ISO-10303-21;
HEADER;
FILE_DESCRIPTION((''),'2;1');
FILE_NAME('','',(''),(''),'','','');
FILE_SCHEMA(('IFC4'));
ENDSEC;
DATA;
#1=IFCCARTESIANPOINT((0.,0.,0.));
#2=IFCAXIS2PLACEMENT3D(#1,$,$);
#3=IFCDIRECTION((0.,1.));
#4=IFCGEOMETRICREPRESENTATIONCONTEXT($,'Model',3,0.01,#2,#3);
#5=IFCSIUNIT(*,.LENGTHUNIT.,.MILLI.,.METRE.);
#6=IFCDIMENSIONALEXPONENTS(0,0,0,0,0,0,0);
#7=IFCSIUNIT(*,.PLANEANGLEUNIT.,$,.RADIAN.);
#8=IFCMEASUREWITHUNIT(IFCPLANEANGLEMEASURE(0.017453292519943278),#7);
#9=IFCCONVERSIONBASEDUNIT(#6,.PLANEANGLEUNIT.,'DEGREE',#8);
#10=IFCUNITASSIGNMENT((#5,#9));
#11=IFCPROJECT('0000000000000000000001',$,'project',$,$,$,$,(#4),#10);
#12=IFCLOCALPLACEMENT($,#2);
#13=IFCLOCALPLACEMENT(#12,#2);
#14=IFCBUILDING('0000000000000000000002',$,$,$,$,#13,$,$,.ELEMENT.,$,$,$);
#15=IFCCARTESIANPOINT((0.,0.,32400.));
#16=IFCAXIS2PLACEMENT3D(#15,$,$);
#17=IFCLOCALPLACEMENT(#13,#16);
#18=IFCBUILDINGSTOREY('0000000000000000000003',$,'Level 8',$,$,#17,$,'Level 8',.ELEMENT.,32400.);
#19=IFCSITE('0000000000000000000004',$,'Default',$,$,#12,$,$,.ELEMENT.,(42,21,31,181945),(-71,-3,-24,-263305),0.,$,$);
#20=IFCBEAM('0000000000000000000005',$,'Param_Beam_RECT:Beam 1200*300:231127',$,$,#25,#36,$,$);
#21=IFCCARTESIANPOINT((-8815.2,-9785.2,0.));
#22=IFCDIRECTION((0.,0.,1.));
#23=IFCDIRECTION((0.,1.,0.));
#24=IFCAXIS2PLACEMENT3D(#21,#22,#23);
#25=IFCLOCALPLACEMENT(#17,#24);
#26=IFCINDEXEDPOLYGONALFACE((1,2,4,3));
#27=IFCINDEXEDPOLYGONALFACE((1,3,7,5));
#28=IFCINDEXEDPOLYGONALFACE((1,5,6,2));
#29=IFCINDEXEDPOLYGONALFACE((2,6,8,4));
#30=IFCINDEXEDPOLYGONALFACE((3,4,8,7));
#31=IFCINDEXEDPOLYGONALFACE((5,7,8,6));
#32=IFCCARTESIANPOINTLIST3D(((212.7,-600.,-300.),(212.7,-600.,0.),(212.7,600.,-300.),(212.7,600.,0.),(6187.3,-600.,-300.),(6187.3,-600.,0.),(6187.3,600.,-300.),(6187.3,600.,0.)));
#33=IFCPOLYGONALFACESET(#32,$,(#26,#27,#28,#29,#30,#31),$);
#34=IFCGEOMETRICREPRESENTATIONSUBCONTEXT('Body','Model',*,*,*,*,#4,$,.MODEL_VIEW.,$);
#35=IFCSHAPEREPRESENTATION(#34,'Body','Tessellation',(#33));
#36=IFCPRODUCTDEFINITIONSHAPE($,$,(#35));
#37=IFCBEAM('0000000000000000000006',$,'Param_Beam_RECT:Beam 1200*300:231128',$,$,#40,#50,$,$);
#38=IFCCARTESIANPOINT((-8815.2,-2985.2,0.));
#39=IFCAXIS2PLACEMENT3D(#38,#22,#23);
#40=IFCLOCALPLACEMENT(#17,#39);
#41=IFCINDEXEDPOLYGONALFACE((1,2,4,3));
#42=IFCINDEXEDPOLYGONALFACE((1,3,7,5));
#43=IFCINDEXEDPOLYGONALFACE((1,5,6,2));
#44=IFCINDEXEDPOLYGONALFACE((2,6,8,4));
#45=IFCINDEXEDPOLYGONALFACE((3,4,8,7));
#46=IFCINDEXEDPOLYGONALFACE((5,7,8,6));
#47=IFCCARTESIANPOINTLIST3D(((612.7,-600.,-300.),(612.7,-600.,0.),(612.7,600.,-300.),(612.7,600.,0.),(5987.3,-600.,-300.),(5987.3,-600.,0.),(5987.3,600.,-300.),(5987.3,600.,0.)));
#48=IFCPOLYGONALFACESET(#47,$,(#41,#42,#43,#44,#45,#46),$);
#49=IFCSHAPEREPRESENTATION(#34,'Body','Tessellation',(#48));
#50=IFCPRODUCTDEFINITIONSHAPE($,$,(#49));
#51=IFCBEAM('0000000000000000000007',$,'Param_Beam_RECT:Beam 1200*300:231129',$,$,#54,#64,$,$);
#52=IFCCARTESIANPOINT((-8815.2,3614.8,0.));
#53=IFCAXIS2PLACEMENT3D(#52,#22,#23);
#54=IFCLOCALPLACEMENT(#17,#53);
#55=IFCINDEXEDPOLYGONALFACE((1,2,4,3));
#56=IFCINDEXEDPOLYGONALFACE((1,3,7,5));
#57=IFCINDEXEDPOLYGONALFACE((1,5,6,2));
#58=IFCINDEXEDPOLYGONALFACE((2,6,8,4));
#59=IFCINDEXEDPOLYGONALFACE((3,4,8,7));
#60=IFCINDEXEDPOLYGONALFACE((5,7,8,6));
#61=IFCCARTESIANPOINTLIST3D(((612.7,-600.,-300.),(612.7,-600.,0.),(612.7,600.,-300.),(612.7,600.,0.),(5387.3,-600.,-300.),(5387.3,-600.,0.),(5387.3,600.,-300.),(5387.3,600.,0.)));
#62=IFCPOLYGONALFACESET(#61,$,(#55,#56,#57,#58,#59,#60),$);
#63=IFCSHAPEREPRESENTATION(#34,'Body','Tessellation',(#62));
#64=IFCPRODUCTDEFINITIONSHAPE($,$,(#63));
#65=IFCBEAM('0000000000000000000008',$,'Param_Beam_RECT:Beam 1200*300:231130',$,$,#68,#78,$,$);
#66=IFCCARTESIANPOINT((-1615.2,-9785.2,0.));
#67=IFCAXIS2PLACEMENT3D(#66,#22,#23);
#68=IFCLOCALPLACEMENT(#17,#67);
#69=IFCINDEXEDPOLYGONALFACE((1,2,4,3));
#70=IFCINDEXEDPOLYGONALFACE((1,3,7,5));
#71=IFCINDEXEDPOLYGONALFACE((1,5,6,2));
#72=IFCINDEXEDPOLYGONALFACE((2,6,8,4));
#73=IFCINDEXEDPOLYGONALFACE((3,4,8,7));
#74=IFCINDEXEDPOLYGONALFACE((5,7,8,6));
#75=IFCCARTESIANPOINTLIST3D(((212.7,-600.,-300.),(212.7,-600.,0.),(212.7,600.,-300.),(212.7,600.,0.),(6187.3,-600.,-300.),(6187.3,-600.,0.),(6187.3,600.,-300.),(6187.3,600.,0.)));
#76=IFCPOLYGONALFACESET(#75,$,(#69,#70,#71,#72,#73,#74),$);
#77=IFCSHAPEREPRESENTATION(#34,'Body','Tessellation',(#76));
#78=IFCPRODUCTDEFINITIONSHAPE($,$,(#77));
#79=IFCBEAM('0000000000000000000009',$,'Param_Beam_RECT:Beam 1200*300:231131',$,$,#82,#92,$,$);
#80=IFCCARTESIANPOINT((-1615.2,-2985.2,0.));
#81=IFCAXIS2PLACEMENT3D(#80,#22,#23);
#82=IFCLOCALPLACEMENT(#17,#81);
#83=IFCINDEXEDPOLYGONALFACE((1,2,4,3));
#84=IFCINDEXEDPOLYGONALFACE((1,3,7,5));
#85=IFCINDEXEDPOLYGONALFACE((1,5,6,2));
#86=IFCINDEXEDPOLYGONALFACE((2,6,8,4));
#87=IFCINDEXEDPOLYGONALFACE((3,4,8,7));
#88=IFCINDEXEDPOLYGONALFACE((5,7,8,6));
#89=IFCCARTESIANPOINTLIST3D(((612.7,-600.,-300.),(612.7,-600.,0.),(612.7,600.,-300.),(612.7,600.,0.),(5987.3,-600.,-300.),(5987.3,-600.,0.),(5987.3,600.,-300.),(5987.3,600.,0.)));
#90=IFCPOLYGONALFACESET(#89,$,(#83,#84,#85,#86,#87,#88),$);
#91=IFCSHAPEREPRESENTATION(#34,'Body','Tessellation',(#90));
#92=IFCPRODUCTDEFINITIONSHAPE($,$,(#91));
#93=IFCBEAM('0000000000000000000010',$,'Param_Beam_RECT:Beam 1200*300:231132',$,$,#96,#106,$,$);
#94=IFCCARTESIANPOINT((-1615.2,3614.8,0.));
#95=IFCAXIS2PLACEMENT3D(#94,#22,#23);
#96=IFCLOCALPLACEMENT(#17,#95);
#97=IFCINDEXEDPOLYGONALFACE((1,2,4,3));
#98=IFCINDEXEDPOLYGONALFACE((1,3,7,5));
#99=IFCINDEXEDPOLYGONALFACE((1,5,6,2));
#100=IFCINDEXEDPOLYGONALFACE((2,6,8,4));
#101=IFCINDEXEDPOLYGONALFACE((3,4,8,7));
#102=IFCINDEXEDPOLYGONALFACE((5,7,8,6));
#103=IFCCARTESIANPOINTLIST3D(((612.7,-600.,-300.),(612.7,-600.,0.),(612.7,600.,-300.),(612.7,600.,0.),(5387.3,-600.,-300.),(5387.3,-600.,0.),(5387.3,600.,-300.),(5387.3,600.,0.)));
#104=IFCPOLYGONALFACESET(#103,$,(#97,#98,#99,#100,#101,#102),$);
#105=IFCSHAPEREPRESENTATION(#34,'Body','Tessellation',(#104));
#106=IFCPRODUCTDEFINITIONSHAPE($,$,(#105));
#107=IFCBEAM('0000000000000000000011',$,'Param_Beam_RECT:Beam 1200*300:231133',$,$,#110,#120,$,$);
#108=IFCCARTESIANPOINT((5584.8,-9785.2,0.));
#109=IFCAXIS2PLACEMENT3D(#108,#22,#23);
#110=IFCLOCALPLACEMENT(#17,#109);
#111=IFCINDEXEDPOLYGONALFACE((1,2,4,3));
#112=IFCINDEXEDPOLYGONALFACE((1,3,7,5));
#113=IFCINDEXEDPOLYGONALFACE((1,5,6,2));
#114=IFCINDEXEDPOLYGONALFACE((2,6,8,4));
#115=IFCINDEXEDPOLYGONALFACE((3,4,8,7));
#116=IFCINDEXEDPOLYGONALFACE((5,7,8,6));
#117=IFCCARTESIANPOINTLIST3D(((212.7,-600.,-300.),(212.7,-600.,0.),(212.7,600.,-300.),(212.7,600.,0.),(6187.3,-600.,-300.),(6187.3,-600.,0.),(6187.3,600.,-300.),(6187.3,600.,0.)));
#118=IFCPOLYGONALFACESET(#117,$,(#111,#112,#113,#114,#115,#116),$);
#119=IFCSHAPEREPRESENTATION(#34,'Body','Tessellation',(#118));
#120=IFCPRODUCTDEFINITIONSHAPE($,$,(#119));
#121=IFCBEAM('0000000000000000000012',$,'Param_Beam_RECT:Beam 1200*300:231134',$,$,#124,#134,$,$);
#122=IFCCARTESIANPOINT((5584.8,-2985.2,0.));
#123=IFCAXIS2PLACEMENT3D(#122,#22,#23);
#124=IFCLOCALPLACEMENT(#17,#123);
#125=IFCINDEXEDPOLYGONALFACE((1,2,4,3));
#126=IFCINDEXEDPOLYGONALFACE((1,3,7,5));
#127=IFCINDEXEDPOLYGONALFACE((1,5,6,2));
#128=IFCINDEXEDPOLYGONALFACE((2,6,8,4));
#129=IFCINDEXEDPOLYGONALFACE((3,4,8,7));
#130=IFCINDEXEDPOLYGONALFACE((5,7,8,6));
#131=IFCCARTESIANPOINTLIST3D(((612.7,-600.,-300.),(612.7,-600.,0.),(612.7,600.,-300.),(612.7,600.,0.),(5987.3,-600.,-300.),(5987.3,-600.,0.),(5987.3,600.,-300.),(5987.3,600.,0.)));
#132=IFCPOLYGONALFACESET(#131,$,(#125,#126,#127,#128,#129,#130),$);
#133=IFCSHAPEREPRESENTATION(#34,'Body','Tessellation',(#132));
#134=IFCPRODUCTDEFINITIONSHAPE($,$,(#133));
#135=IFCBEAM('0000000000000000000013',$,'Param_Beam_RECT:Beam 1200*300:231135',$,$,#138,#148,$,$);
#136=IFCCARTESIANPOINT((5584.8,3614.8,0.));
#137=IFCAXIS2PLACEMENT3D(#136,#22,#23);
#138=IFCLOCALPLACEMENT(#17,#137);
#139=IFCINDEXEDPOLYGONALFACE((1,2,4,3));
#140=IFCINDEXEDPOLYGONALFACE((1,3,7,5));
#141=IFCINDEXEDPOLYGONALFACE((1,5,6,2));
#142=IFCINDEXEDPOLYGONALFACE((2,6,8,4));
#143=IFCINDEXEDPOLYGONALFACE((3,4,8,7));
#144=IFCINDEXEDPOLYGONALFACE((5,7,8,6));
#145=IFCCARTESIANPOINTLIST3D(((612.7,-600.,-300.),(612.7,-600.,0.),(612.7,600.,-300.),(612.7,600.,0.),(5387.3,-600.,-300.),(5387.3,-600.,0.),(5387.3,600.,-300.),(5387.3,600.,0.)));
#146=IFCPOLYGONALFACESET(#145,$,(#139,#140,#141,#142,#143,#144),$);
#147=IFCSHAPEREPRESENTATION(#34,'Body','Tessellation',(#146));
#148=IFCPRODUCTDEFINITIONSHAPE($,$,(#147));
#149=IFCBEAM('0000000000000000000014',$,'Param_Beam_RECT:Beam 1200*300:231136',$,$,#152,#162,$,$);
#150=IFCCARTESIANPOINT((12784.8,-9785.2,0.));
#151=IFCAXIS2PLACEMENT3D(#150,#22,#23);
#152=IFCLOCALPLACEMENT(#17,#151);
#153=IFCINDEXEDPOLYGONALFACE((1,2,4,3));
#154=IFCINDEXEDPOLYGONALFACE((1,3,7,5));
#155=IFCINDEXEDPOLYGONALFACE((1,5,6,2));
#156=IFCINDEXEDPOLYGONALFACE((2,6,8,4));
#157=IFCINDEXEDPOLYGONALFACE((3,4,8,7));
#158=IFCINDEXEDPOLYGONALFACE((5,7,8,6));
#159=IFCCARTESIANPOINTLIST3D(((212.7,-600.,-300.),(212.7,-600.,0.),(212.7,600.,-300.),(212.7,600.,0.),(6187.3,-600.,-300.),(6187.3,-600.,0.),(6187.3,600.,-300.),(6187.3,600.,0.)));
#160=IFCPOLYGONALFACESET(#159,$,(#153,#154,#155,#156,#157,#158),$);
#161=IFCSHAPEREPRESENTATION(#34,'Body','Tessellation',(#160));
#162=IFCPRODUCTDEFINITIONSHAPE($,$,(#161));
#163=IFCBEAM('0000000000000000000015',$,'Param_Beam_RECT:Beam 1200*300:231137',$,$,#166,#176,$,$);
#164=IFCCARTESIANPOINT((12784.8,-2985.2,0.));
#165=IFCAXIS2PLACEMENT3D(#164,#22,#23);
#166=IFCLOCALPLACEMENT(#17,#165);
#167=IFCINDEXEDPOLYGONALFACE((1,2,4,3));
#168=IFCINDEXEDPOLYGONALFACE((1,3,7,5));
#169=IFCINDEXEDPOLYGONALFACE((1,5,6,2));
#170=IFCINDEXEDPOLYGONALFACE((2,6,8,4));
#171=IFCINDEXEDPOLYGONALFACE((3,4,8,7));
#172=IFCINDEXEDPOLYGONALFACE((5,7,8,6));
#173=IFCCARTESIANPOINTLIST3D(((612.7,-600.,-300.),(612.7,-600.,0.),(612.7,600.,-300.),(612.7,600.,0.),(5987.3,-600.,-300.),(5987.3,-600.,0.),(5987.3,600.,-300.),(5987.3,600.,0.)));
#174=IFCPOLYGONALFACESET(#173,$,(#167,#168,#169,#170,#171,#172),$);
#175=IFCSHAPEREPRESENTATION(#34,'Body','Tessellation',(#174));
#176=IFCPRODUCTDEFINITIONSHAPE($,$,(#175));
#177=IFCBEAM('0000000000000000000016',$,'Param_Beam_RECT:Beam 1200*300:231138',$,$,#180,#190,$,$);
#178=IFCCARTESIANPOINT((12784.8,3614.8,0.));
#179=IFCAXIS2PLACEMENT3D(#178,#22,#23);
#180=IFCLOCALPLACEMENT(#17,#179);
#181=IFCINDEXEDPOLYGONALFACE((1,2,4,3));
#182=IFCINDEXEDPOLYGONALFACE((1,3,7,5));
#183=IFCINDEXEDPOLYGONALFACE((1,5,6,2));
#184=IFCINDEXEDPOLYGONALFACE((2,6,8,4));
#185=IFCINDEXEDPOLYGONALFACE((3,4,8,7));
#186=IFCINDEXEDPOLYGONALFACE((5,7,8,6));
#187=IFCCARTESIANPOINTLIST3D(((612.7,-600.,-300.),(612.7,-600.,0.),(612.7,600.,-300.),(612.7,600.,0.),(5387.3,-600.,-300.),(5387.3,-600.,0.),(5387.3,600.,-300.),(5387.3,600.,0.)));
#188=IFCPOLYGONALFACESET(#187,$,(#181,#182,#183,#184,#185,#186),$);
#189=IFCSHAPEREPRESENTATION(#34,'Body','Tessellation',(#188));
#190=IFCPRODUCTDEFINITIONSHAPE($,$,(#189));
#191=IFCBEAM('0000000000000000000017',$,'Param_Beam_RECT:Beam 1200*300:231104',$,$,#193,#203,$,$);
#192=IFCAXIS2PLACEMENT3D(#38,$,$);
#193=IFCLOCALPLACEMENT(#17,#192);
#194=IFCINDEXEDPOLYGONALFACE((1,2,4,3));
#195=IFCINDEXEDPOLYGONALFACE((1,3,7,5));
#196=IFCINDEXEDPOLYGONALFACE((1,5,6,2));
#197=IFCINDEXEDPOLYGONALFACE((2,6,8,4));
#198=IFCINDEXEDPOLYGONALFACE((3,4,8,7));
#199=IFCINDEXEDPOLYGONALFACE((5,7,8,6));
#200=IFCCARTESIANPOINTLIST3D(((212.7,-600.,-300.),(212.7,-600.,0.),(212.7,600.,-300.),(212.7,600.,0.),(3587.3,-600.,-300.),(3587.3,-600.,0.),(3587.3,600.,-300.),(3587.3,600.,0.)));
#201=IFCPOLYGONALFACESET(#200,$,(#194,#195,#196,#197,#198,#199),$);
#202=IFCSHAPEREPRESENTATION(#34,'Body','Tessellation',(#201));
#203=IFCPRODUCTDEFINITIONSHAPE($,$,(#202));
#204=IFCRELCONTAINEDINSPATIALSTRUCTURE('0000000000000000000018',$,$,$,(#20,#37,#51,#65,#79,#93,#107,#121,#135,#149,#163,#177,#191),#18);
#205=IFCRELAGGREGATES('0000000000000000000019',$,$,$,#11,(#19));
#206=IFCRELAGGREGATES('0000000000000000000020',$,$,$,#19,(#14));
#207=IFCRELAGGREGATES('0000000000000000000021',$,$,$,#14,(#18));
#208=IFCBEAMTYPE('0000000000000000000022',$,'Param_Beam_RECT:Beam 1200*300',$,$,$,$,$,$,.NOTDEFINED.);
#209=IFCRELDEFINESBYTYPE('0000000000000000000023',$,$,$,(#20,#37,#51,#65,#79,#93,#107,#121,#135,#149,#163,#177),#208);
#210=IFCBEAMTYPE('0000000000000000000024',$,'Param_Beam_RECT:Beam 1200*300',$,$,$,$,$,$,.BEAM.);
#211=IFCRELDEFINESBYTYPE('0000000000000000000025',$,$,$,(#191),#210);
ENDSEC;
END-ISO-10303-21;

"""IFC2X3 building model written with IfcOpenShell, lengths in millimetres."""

from ifc_helpers import new_model, entity, si_unit, converted_unit, direction, frame, frame_2d, origin, origin_2d_with_axis, place, context, subcontext, project, spatial, rectangle, extrude, type_object, element, save


model = new_model("IFC2X3")

# Units and contexts
model_context = context("Model", 3, precision=0.01, world=origin(), true_north=direction((0.0, 1.0)))
body_context = subcontext(model_context, "Body", "Model", "MODEL_VIEW")
ifc_project = project(units=[si_unit("LENGTHUNIT", "METRE", prefix="MILLI"), converted_unit("PLANEANGLEUNIT", "DEGREE", entity("IfcPlaneAngleMeasure", 0.017453292519943278), si_unit("PLANEANGLEUNIT", "RADIAN"), dimensions=[0, 0, 0, 0, 0, 0, 0])], contexts=[model_context])

# Site, building, storey
site_placement = place(None, origin())
site = spatial("IfcSite", under=ifc_project, at=site_placement, Name="Default", CompositionType="ELEMENT", RefLatitude=(42, 21, 31, 181945), RefLongitude=(-71, -3, -24, -263305), RefElevation=0.0)
building_placement = place(site_placement, origin())
building = spatial("IfcBuilding", under=site, at=building_placement, CompositionType="ELEMENT")
storey_placement = place(building_placement, frame((0.0, 0.0, 32400.0)))
storey = spatial("IfcBuildingStorey", under=building, at=storey_placement, Name="Level 8", LongName="Level 8", CompositionType="ELEMENT", Elevation=32400.0)

# Beams
beam_type_1 = type_object("IfcBeamType", Name="Param_Beam_RECT:Beam 1200*300", PredefinedType="NOTDEFINED")
beam_1_placement = place(storey_placement, frame((-8815.2, -9785.2, 0.0), z_axis=(0.0, 0.0, 1.0), x_axis=(0.0, 1.0, 0.0)))
element("IfcBeam", 1, at=beam_1_placement, inside=storey, type_object=beam_type_1, Name="Param_Beam_RECT:Beam 1200*300:231127", context=body_context, shape_type="SweptSolid", body=[
    extrude(rectangle(XDim=300.0, YDim=1200.0, at=frame_2d((0.0, 0.0), x_axis=(1.0, 0.0))), frame((212.7, 0.0, -150.0), z_axis=(1.0, 0.0, 0.0), x_axis=(0.0, 0.0, -1.0)), (0.0, 0.0, 1.0), 5974.6),
])
beam_2_placement = place(storey_placement, frame((-8815.2, -2985.2, 0.0), z_axis=(0.0, 0.0, 1.0), x_axis=(0.0, 1.0, 0.0)))
element("IfcBeam", 2, at=beam_2_placement, inside=storey, type_object=beam_type_1, Name="Param_Beam_RECT:Beam 1200*300:231128", context=body_context, shape_type="SweptSolid", body=[
    extrude(rectangle(XDim=300.0, YDim=1200.0, at=frame_2d((0.0, 0.0), x_axis=(1.0, 0.0))), frame((612.7, 0.0, -150.0), z_axis=(1.0, 0.0, 0.0), x_axis=(0.0, 0.0, -1.0)), (0.0, 0.0, 1.0), 5374.6),
])
beam_3_placement = place(storey_placement, frame((-8815.2, 3614.8, 0.0), z_axis=(0.0, 0.0, 1.0), x_axis=(0.0, 1.0, 0.0)))
element("IfcBeam", 3, at=beam_3_placement, inside=storey, type_object=beam_type_1, Name="Param_Beam_RECT:Beam 1200*300:231129", context=body_context, shape_type="SweptSolid", body=[
    extrude(rectangle(XDim=300.0, YDim=1200.0, at=frame_2d((0.0, 0.0), x_axis=(1.0, 0.0))), frame((612.7, 0.0, -150.0), z_axis=(1.0, 0.0, 0.0), x_axis=(0.0, 0.0, -1.0)), (0.0, 0.0, 1.0), 4774.6),
])
beam_4_placement = place(storey_placement, frame((-1615.2, -9785.2, 0.0), z_axis=(0.0, 0.0, 1.0), x_axis=(0.0, 1.0, 0.0)))
element("IfcBeam", 4, at=beam_4_placement, inside=storey, type_object=beam_type_1, Name="Param_Beam_RECT:Beam 1200*300:231130", context=body_context, shape_type="SweptSolid", body=[
    extrude(rectangle(XDim=300.0, YDim=1200.0, at=frame_2d((0.0, 0.0), x_axis=(1.0, 0.0))), frame((212.7, 0.0, -150.0), z_axis=(1.0, 0.0, 0.0), x_axis=(0.0, 0.0, -1.0)), (0.0, 0.0, 1.0), 5974.6),
])
beam_5_placement = place(storey_placement, frame((-1615.2, -2985.2, 0.0), z_axis=(0.0, 0.0, 1.0), x_axis=(0.0, 1.0, 0.0)))
element("IfcBeam", 5, at=beam_5_placement, inside=storey, type_object=beam_type_1, Name="Param_Beam_RECT:Beam 1200*300:231131", context=body_context, shape_type="SweptSolid", body=[
    extrude(rectangle(XDim=300.0, YDim=1200.0, at=frame_2d((0.0, 0.0), x_axis=(1.0, 0.0))), frame((612.7, 0.0, -150.0), z_axis=(1.0, 0.0, 0.0), x_axis=(0.0, 0.0, -1.0)), (0.0, 0.0, 1.0), 5374.6),
])
beam_6_placement = place(storey_placement, frame((-1615.2, 3614.8, 0.0), z_axis=(0.0, 0.0, 1.0), x_axis=(0.0, 1.0, 0.0)))
element("IfcBeam", 6, at=beam_6_placement, inside=storey, type_object=beam_type_1, Name="Param_Beam_RECT:Beam 1200*300:231132", context=body_context, shape_type="SweptSolid", body=[
    extrude(rectangle(XDim=300.0, YDim=1200.0, at=frame_2d((0.0, 0.0), x_axis=(1.0, 0.0))), frame((612.7, 0.0, -150.0), z_axis=(1.0, 0.0, 0.0), x_axis=(0.0, 0.0, -1.0)), (0.0, 0.0, 1.0), 4774.6),
])
beam_7_placement = place(storey_placement, frame((5584.8, -9785.2, 0.0), z_axis=(0.0, 0.0, 1.0), x_axis=(0.0, 1.0, 0.0)))
element("IfcBeam", 7, at=beam_7_placement, inside=storey, type_object=beam_type_1, Name="Param_Beam_RECT:Beam 1200*300:231133", context=body_context, shape_type="SweptSolid", body=[
    extrude(rectangle(XDim=300.0, YDim=1200.0, at=frame_2d((0.0, 0.0), x_axis=(1.0, 0.0))), frame((212.7, 0.0, -150.0), z_axis=(1.0, 0.0, 0.0), x_axis=(0.0, 0.0, -1.0)), (0.0, 0.0, 1.0), 5974.6),
])
beam_8_placement = place(storey_placement, frame((5584.8, -2985.2, 0.0), z_axis=(0.0, 0.0, 1.0), x_axis=(0.0, 1.0, 0.0)))
element("IfcBeam", 8, at=beam_8_placement, inside=storey, type_object=beam_type_1, Name="Param_Beam_RECT:Beam 1200*300:231134", context=body_context, shape_type="SweptSolid", body=[
    extrude(rectangle(XDim=300.0, YDim=1200.0, at=frame_2d((0.0, 0.0), x_axis=(1.0, 0.0))), frame((612.7, 0.0, -150.0), z_axis=(1.0, 0.0, 0.0), x_axis=(0.0, 0.0, -1.0)), (0.0, 0.0, 1.0), 5374.6),
])
beam_9_placement = place(storey_placement, frame((5584.8, 3614.8, 0.0), z_axis=(0.0, 0.0, 1.0), x_axis=(0.0, 1.0, 0.0)))
element("IfcBeam", 9, at=beam_9_placement, inside=storey, type_object=beam_type_1, Name="Param_Beam_RECT:Beam 1200*300:231135", context=body_context, shape_type="SweptSolid", body=[
    extrude(rectangle(XDim=300.0, YDim=1200.0, at=frame_2d((0.0, 0.0), x_axis=(1.0, 0.0))), frame((612.7, 0.0, -150.0), z_axis=(1.0, 0.0, 0.0), x_axis=(0.0, 0.0, -1.0)), (0.0, 0.0, 1.0), 4774.6),
])
beam_10_placement = place(storey_placement, frame((12784.8, -9785.2, 0.0), z_axis=(0.0, 0.0, 1.0), x_axis=(0.0, 1.0, 0.0)))
element("IfcBeam", 10, at=beam_10_placement, inside=storey, type_object=beam_type_1, Name="Param_Beam_RECT:Beam 1200*300:231136", context=body_context, shape_type="SweptSolid", body=[
    extrude(rectangle(XDim=300.0, YDim=1200.0, at=origin_2d_with_axis()), frame((212.7, 0.0, -150.0), z_axis=(1.0, 0.0, 0.0), x_axis=(0.0, 0.0, -1.0)), (0.0, 0.0, 1.0), 5974.6),
])
beam_11_placement = place(storey_placement, frame((12784.8, -2985.2, 0.0), z_axis=(0.0, 0.0, 1.0), x_axis=(0.0, 1.0, 0.0)))
element("IfcBeam", 11, at=beam_11_placement, inside=storey, type_object=beam_type_1, Name="Param_Beam_RECT:Beam 1200*300:231137", context=body_context, shape_type="SweptSolid", body=[
    extrude(rectangle(XDim=300.0, YDim=1200.0, at=frame_2d((0.0, 0.0), x_axis=(1.0, 0.0))), frame((612.7, 0.0, -150.0), z_axis=(1.0, 0.0, 0.0), x_axis=(0.0, 0.0, -1.0)), (0.0, 0.0, 1.0), 5374.6),
])
beam_12_placement = place(storey_placement, frame((12784.8, 3614.8, 0.0), z_axis=(0.0, 0.0, 1.0), x_axis=(0.0, 1.0, 0.0)))
element("IfcBeam", 12, at=beam_12_placement, inside=storey, type_object=beam_type_1, Name="Param_Beam_RECT:Beam 1200*300:231138", context=body_context, shape_type="SweptSolid", body=[
    extrude(rectangle(XDim=300.0, YDim=1200.0, at=origin_2d_with_axis()), frame((612.7, 0.0, -150.0), z_axis=(1.0, 0.0, 0.0), x_axis=(0.0, 0.0, -1.0)), (0.0, 0.0, 1.0), 4774.6),
])
beam_type_2 = type_object("IfcBeamType", Name="Param_Beam_RECT:Beam 1200*300", PredefinedType="BEAM")
beam_13_placement = place(storey_placement, frame((-8815.2, -2985.2, 0.0)))
element("IfcBeam", 13, at=beam_13_placement, inside=storey, type_object=beam_type_2, Name="Param_Beam_RECT:Beam 1200*300:231104", context=body_context, shape_type="SweptSolid", body=[
    extrude(rectangle(XDim=300.0, YDim=1200.0, at=frame_2d((0.0, 0.0), x_axis=(1.0, 0.0))), frame((212.7, 0.0, -150.0), z_axis=(1.0, 0.0, 0.0), x_axis=(0.0, 0.0, -1.0)), (0.0, 0.0, 1.0), 3374.6),
])

save(model, "model.ifc")
